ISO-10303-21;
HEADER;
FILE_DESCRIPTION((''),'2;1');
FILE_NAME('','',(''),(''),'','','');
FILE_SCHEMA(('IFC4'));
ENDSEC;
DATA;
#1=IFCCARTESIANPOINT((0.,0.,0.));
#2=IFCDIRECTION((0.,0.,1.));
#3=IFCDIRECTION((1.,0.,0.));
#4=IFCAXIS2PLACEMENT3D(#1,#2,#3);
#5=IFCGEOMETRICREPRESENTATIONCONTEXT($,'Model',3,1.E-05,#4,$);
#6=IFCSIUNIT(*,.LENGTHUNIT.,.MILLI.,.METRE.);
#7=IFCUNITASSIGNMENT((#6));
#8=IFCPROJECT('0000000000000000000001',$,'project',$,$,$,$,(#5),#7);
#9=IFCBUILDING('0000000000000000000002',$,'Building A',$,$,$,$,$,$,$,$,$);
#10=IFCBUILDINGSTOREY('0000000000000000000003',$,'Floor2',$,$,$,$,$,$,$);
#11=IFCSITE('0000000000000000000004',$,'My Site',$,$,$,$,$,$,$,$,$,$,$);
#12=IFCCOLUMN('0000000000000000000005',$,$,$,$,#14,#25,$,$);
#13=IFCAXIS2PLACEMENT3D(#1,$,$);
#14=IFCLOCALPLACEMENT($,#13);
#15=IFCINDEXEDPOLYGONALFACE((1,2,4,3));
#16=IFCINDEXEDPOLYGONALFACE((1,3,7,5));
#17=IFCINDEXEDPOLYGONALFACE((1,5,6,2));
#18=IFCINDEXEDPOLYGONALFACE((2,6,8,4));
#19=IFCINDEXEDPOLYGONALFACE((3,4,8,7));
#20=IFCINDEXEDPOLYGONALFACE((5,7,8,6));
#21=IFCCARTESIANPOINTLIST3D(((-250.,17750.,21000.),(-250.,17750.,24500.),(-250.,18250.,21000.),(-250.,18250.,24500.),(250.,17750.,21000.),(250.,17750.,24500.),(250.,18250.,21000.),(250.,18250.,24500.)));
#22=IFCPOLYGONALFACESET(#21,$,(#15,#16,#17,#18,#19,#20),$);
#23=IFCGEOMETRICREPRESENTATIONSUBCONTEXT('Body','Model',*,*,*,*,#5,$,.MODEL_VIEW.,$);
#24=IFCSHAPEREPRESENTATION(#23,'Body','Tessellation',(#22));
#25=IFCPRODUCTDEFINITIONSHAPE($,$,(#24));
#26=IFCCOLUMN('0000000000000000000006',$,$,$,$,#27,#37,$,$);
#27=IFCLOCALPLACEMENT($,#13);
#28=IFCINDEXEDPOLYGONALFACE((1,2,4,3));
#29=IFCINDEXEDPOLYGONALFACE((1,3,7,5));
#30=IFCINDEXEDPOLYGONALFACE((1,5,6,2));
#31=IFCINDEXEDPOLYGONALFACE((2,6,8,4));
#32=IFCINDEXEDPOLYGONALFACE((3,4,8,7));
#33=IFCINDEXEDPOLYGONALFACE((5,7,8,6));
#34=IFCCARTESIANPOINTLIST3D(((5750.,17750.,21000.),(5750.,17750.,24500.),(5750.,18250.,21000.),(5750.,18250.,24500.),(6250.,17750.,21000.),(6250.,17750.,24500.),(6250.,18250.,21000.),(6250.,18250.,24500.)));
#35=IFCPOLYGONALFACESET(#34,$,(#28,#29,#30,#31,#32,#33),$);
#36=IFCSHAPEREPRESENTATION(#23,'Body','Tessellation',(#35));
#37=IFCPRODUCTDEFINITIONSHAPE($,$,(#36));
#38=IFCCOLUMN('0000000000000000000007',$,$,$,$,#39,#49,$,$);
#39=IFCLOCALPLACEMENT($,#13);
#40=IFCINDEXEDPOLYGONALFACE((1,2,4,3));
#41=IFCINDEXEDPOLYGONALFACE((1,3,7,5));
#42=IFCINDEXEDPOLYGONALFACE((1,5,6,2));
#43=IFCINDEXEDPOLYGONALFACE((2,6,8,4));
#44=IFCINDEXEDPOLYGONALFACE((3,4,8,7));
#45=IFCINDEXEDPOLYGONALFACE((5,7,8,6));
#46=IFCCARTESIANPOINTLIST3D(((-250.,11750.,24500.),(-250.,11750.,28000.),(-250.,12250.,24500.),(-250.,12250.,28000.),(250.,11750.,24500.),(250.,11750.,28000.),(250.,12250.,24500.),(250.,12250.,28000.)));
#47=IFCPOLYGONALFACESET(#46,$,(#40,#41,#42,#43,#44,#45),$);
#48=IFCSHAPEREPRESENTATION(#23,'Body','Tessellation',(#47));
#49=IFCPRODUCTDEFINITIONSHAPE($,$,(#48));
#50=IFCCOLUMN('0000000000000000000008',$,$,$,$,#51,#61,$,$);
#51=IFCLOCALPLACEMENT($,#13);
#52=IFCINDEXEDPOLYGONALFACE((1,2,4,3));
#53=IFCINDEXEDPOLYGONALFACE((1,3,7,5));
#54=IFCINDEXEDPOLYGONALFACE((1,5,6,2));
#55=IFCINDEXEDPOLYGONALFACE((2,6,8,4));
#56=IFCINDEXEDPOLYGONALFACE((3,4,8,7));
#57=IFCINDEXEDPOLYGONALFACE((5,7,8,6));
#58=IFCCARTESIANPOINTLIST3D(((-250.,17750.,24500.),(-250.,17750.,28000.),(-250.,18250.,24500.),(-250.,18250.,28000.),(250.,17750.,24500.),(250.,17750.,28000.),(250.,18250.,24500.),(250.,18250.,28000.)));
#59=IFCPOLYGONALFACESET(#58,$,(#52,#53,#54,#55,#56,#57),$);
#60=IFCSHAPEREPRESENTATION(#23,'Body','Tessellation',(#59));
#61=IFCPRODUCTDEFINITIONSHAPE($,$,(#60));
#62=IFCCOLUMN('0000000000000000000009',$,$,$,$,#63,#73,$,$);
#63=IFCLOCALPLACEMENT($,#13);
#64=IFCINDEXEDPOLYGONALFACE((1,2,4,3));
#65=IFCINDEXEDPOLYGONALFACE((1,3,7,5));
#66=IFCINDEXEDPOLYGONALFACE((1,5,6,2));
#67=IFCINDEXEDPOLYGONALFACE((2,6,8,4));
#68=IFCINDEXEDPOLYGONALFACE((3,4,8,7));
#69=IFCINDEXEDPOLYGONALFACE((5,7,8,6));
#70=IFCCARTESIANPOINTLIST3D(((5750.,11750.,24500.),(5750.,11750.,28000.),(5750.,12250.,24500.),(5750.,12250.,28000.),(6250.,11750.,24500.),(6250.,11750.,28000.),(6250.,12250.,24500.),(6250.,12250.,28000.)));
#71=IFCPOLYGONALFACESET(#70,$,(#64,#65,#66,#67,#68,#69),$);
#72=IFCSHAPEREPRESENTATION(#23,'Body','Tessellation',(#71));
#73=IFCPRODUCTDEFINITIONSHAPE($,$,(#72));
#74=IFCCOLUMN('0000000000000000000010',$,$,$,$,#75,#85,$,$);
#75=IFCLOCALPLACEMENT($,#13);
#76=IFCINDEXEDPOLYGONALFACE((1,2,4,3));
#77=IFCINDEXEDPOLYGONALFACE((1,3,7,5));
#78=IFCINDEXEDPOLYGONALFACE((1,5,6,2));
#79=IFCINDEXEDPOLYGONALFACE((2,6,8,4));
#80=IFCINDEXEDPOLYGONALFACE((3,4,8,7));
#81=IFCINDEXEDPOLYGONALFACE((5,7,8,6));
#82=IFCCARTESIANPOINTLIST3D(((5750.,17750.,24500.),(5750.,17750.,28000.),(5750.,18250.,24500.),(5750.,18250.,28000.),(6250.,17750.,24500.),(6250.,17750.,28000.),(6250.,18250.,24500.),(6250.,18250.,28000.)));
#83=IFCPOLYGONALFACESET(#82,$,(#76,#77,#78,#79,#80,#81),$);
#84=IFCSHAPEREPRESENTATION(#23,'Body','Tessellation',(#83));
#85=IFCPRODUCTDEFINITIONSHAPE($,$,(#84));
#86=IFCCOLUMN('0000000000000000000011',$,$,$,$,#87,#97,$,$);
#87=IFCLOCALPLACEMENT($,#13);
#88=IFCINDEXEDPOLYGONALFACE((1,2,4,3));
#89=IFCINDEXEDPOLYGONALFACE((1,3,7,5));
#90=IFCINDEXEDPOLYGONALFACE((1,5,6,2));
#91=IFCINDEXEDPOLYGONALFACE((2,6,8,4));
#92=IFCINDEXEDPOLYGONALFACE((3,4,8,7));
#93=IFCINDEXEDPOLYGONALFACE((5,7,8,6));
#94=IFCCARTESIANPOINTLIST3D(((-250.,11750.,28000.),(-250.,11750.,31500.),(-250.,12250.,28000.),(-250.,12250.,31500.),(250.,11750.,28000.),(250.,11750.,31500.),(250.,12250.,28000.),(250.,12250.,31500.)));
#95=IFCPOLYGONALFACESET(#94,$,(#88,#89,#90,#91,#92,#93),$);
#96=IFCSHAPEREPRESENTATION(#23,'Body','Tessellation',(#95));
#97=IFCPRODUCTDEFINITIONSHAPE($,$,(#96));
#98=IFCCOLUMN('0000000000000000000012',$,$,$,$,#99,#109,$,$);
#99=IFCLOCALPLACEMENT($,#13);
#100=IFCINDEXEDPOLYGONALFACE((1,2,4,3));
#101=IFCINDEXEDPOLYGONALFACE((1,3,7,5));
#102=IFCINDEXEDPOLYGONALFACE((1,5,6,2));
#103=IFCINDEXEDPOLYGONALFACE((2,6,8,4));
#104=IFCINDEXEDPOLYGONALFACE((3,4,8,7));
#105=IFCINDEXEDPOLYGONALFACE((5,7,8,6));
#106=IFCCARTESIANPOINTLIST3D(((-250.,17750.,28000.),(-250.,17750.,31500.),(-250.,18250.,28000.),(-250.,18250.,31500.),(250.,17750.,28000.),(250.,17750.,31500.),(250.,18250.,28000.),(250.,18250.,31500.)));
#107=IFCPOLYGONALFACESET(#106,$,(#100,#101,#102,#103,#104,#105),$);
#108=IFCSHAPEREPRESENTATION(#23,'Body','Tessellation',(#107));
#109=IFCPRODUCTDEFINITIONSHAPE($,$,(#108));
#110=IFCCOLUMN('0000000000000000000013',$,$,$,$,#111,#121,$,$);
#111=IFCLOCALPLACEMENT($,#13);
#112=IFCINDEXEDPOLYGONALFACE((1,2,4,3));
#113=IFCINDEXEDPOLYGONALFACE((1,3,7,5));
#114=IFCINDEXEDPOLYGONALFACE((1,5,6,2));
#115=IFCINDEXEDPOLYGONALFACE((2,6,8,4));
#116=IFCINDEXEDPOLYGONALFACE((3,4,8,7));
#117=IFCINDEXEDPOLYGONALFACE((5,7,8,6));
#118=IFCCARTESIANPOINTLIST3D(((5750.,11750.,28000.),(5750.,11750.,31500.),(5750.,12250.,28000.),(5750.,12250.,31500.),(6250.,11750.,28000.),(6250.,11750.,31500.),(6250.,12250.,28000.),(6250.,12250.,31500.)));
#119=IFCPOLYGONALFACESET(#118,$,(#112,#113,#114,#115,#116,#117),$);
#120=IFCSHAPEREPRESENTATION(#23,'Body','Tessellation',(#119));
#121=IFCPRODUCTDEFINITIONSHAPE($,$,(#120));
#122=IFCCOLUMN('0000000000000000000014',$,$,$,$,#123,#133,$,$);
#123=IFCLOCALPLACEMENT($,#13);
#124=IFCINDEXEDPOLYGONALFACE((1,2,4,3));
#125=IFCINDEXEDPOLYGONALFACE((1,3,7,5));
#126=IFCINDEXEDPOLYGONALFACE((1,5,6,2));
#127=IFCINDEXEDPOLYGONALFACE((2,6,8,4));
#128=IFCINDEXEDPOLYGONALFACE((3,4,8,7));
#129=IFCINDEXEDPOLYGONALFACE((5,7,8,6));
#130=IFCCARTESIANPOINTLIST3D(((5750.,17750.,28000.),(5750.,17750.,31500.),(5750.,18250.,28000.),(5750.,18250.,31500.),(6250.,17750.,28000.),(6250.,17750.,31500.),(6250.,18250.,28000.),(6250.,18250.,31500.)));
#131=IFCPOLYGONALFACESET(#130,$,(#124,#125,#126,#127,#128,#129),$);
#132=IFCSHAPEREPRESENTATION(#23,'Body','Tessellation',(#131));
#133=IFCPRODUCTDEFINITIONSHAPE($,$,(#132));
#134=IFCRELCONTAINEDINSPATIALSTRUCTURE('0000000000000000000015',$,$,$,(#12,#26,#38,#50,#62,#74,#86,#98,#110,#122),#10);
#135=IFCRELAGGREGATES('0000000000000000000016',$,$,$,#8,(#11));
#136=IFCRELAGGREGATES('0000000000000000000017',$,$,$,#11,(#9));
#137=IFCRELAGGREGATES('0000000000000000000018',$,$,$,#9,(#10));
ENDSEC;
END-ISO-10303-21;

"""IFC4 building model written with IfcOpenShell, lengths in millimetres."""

from ifc_helpers import new_model, si_unit, frame, origin_with_axes, place, context, subcontext, project, spatial, line, indexed_curve, outline, extrude, element, save


model = new_model("IFC4")

# Units and contexts
model_context = context("Model", 3, precision=1e-05, world=origin_with_axes())
body_context = subcontext(model_context, "Body", "Model", "MODEL_VIEW")
ifc_project = project(units=[si_unit("LENGTHUNIT", "METRE", prefix="MILLI")], contexts=[model_context])

# Site, building, storey
site = spatial("IfcSite", under=ifc_project, Name="My Site")
building = spatial("IfcBuilding", under=site, Name="Building A")
storey = spatial("IfcBuildingStorey", under=building, Name="Floor2")

# Columns
for number, where, z_axis, x_axis in (
    (1, (0.0, 18000.0, 21000.0), (0.0, 0.0, 1.0), (1.0, 0.0, 0.0)),
    (2, (6000.0, 18000.0, 21000.0), (0.0, 0.0, 1.0), (1.0, 0.0, 0.0)),
    (3, (0.0, 12000.0, 24500.0), (0.0, 0.0, 1.0), (1.0, 0.0, 0.0)),
    (4, (0.0, 18000.0, 24500.0), (0.0, 0.0, 1.0), (1.0, 0.0, 0.0)),
    (5, (6000.0, 12000.0, 24500.0), (0.0, 0.0, 1.0), (1.0, 0.0, 0.0)),
    (6, (6000.0, 18000.0, 24500.0), (0.0, 0.0, 1.0), (1.0, 0.0, 0.0)),
    (7, (0.0, 12000.0, 28000.0), (0.0, 0.0, 1.0), (1.0, 0.0, 0.0)),
    (8, (0.0, 18000.0, 28000.0), (0.0, 0.0, 1.0), (1.0, 0.0, 0.0)),
    (9, (6000.0, 12000.0, 28000.0), (0.0, 0.0, 1.0), (1.0, 0.0, 0.0)),
    (10, (6000.0, 18000.0, 28000.0), (0.0, 0.0, 1.0), (1.0, 0.0, 0.0)),
):
    element("IfcColumn", number, at=place(None, frame(where, z_axis=z_axis, x_axis=x_axis)), inside=storey, context=body_context, shape_type="SweptSolid", body=[
        extrude(outline(indexed_curve([(-250.0, -250.0), (250.0, -250.0), (250.0, 250.0), (-250.0, 250.0)], segments=[line(1, 2, 3, 4, 1)])), origin_with_axes(), (0.0, 0.0, 1.0), 3500.0),
    ])

save(model, "model.ifc")
